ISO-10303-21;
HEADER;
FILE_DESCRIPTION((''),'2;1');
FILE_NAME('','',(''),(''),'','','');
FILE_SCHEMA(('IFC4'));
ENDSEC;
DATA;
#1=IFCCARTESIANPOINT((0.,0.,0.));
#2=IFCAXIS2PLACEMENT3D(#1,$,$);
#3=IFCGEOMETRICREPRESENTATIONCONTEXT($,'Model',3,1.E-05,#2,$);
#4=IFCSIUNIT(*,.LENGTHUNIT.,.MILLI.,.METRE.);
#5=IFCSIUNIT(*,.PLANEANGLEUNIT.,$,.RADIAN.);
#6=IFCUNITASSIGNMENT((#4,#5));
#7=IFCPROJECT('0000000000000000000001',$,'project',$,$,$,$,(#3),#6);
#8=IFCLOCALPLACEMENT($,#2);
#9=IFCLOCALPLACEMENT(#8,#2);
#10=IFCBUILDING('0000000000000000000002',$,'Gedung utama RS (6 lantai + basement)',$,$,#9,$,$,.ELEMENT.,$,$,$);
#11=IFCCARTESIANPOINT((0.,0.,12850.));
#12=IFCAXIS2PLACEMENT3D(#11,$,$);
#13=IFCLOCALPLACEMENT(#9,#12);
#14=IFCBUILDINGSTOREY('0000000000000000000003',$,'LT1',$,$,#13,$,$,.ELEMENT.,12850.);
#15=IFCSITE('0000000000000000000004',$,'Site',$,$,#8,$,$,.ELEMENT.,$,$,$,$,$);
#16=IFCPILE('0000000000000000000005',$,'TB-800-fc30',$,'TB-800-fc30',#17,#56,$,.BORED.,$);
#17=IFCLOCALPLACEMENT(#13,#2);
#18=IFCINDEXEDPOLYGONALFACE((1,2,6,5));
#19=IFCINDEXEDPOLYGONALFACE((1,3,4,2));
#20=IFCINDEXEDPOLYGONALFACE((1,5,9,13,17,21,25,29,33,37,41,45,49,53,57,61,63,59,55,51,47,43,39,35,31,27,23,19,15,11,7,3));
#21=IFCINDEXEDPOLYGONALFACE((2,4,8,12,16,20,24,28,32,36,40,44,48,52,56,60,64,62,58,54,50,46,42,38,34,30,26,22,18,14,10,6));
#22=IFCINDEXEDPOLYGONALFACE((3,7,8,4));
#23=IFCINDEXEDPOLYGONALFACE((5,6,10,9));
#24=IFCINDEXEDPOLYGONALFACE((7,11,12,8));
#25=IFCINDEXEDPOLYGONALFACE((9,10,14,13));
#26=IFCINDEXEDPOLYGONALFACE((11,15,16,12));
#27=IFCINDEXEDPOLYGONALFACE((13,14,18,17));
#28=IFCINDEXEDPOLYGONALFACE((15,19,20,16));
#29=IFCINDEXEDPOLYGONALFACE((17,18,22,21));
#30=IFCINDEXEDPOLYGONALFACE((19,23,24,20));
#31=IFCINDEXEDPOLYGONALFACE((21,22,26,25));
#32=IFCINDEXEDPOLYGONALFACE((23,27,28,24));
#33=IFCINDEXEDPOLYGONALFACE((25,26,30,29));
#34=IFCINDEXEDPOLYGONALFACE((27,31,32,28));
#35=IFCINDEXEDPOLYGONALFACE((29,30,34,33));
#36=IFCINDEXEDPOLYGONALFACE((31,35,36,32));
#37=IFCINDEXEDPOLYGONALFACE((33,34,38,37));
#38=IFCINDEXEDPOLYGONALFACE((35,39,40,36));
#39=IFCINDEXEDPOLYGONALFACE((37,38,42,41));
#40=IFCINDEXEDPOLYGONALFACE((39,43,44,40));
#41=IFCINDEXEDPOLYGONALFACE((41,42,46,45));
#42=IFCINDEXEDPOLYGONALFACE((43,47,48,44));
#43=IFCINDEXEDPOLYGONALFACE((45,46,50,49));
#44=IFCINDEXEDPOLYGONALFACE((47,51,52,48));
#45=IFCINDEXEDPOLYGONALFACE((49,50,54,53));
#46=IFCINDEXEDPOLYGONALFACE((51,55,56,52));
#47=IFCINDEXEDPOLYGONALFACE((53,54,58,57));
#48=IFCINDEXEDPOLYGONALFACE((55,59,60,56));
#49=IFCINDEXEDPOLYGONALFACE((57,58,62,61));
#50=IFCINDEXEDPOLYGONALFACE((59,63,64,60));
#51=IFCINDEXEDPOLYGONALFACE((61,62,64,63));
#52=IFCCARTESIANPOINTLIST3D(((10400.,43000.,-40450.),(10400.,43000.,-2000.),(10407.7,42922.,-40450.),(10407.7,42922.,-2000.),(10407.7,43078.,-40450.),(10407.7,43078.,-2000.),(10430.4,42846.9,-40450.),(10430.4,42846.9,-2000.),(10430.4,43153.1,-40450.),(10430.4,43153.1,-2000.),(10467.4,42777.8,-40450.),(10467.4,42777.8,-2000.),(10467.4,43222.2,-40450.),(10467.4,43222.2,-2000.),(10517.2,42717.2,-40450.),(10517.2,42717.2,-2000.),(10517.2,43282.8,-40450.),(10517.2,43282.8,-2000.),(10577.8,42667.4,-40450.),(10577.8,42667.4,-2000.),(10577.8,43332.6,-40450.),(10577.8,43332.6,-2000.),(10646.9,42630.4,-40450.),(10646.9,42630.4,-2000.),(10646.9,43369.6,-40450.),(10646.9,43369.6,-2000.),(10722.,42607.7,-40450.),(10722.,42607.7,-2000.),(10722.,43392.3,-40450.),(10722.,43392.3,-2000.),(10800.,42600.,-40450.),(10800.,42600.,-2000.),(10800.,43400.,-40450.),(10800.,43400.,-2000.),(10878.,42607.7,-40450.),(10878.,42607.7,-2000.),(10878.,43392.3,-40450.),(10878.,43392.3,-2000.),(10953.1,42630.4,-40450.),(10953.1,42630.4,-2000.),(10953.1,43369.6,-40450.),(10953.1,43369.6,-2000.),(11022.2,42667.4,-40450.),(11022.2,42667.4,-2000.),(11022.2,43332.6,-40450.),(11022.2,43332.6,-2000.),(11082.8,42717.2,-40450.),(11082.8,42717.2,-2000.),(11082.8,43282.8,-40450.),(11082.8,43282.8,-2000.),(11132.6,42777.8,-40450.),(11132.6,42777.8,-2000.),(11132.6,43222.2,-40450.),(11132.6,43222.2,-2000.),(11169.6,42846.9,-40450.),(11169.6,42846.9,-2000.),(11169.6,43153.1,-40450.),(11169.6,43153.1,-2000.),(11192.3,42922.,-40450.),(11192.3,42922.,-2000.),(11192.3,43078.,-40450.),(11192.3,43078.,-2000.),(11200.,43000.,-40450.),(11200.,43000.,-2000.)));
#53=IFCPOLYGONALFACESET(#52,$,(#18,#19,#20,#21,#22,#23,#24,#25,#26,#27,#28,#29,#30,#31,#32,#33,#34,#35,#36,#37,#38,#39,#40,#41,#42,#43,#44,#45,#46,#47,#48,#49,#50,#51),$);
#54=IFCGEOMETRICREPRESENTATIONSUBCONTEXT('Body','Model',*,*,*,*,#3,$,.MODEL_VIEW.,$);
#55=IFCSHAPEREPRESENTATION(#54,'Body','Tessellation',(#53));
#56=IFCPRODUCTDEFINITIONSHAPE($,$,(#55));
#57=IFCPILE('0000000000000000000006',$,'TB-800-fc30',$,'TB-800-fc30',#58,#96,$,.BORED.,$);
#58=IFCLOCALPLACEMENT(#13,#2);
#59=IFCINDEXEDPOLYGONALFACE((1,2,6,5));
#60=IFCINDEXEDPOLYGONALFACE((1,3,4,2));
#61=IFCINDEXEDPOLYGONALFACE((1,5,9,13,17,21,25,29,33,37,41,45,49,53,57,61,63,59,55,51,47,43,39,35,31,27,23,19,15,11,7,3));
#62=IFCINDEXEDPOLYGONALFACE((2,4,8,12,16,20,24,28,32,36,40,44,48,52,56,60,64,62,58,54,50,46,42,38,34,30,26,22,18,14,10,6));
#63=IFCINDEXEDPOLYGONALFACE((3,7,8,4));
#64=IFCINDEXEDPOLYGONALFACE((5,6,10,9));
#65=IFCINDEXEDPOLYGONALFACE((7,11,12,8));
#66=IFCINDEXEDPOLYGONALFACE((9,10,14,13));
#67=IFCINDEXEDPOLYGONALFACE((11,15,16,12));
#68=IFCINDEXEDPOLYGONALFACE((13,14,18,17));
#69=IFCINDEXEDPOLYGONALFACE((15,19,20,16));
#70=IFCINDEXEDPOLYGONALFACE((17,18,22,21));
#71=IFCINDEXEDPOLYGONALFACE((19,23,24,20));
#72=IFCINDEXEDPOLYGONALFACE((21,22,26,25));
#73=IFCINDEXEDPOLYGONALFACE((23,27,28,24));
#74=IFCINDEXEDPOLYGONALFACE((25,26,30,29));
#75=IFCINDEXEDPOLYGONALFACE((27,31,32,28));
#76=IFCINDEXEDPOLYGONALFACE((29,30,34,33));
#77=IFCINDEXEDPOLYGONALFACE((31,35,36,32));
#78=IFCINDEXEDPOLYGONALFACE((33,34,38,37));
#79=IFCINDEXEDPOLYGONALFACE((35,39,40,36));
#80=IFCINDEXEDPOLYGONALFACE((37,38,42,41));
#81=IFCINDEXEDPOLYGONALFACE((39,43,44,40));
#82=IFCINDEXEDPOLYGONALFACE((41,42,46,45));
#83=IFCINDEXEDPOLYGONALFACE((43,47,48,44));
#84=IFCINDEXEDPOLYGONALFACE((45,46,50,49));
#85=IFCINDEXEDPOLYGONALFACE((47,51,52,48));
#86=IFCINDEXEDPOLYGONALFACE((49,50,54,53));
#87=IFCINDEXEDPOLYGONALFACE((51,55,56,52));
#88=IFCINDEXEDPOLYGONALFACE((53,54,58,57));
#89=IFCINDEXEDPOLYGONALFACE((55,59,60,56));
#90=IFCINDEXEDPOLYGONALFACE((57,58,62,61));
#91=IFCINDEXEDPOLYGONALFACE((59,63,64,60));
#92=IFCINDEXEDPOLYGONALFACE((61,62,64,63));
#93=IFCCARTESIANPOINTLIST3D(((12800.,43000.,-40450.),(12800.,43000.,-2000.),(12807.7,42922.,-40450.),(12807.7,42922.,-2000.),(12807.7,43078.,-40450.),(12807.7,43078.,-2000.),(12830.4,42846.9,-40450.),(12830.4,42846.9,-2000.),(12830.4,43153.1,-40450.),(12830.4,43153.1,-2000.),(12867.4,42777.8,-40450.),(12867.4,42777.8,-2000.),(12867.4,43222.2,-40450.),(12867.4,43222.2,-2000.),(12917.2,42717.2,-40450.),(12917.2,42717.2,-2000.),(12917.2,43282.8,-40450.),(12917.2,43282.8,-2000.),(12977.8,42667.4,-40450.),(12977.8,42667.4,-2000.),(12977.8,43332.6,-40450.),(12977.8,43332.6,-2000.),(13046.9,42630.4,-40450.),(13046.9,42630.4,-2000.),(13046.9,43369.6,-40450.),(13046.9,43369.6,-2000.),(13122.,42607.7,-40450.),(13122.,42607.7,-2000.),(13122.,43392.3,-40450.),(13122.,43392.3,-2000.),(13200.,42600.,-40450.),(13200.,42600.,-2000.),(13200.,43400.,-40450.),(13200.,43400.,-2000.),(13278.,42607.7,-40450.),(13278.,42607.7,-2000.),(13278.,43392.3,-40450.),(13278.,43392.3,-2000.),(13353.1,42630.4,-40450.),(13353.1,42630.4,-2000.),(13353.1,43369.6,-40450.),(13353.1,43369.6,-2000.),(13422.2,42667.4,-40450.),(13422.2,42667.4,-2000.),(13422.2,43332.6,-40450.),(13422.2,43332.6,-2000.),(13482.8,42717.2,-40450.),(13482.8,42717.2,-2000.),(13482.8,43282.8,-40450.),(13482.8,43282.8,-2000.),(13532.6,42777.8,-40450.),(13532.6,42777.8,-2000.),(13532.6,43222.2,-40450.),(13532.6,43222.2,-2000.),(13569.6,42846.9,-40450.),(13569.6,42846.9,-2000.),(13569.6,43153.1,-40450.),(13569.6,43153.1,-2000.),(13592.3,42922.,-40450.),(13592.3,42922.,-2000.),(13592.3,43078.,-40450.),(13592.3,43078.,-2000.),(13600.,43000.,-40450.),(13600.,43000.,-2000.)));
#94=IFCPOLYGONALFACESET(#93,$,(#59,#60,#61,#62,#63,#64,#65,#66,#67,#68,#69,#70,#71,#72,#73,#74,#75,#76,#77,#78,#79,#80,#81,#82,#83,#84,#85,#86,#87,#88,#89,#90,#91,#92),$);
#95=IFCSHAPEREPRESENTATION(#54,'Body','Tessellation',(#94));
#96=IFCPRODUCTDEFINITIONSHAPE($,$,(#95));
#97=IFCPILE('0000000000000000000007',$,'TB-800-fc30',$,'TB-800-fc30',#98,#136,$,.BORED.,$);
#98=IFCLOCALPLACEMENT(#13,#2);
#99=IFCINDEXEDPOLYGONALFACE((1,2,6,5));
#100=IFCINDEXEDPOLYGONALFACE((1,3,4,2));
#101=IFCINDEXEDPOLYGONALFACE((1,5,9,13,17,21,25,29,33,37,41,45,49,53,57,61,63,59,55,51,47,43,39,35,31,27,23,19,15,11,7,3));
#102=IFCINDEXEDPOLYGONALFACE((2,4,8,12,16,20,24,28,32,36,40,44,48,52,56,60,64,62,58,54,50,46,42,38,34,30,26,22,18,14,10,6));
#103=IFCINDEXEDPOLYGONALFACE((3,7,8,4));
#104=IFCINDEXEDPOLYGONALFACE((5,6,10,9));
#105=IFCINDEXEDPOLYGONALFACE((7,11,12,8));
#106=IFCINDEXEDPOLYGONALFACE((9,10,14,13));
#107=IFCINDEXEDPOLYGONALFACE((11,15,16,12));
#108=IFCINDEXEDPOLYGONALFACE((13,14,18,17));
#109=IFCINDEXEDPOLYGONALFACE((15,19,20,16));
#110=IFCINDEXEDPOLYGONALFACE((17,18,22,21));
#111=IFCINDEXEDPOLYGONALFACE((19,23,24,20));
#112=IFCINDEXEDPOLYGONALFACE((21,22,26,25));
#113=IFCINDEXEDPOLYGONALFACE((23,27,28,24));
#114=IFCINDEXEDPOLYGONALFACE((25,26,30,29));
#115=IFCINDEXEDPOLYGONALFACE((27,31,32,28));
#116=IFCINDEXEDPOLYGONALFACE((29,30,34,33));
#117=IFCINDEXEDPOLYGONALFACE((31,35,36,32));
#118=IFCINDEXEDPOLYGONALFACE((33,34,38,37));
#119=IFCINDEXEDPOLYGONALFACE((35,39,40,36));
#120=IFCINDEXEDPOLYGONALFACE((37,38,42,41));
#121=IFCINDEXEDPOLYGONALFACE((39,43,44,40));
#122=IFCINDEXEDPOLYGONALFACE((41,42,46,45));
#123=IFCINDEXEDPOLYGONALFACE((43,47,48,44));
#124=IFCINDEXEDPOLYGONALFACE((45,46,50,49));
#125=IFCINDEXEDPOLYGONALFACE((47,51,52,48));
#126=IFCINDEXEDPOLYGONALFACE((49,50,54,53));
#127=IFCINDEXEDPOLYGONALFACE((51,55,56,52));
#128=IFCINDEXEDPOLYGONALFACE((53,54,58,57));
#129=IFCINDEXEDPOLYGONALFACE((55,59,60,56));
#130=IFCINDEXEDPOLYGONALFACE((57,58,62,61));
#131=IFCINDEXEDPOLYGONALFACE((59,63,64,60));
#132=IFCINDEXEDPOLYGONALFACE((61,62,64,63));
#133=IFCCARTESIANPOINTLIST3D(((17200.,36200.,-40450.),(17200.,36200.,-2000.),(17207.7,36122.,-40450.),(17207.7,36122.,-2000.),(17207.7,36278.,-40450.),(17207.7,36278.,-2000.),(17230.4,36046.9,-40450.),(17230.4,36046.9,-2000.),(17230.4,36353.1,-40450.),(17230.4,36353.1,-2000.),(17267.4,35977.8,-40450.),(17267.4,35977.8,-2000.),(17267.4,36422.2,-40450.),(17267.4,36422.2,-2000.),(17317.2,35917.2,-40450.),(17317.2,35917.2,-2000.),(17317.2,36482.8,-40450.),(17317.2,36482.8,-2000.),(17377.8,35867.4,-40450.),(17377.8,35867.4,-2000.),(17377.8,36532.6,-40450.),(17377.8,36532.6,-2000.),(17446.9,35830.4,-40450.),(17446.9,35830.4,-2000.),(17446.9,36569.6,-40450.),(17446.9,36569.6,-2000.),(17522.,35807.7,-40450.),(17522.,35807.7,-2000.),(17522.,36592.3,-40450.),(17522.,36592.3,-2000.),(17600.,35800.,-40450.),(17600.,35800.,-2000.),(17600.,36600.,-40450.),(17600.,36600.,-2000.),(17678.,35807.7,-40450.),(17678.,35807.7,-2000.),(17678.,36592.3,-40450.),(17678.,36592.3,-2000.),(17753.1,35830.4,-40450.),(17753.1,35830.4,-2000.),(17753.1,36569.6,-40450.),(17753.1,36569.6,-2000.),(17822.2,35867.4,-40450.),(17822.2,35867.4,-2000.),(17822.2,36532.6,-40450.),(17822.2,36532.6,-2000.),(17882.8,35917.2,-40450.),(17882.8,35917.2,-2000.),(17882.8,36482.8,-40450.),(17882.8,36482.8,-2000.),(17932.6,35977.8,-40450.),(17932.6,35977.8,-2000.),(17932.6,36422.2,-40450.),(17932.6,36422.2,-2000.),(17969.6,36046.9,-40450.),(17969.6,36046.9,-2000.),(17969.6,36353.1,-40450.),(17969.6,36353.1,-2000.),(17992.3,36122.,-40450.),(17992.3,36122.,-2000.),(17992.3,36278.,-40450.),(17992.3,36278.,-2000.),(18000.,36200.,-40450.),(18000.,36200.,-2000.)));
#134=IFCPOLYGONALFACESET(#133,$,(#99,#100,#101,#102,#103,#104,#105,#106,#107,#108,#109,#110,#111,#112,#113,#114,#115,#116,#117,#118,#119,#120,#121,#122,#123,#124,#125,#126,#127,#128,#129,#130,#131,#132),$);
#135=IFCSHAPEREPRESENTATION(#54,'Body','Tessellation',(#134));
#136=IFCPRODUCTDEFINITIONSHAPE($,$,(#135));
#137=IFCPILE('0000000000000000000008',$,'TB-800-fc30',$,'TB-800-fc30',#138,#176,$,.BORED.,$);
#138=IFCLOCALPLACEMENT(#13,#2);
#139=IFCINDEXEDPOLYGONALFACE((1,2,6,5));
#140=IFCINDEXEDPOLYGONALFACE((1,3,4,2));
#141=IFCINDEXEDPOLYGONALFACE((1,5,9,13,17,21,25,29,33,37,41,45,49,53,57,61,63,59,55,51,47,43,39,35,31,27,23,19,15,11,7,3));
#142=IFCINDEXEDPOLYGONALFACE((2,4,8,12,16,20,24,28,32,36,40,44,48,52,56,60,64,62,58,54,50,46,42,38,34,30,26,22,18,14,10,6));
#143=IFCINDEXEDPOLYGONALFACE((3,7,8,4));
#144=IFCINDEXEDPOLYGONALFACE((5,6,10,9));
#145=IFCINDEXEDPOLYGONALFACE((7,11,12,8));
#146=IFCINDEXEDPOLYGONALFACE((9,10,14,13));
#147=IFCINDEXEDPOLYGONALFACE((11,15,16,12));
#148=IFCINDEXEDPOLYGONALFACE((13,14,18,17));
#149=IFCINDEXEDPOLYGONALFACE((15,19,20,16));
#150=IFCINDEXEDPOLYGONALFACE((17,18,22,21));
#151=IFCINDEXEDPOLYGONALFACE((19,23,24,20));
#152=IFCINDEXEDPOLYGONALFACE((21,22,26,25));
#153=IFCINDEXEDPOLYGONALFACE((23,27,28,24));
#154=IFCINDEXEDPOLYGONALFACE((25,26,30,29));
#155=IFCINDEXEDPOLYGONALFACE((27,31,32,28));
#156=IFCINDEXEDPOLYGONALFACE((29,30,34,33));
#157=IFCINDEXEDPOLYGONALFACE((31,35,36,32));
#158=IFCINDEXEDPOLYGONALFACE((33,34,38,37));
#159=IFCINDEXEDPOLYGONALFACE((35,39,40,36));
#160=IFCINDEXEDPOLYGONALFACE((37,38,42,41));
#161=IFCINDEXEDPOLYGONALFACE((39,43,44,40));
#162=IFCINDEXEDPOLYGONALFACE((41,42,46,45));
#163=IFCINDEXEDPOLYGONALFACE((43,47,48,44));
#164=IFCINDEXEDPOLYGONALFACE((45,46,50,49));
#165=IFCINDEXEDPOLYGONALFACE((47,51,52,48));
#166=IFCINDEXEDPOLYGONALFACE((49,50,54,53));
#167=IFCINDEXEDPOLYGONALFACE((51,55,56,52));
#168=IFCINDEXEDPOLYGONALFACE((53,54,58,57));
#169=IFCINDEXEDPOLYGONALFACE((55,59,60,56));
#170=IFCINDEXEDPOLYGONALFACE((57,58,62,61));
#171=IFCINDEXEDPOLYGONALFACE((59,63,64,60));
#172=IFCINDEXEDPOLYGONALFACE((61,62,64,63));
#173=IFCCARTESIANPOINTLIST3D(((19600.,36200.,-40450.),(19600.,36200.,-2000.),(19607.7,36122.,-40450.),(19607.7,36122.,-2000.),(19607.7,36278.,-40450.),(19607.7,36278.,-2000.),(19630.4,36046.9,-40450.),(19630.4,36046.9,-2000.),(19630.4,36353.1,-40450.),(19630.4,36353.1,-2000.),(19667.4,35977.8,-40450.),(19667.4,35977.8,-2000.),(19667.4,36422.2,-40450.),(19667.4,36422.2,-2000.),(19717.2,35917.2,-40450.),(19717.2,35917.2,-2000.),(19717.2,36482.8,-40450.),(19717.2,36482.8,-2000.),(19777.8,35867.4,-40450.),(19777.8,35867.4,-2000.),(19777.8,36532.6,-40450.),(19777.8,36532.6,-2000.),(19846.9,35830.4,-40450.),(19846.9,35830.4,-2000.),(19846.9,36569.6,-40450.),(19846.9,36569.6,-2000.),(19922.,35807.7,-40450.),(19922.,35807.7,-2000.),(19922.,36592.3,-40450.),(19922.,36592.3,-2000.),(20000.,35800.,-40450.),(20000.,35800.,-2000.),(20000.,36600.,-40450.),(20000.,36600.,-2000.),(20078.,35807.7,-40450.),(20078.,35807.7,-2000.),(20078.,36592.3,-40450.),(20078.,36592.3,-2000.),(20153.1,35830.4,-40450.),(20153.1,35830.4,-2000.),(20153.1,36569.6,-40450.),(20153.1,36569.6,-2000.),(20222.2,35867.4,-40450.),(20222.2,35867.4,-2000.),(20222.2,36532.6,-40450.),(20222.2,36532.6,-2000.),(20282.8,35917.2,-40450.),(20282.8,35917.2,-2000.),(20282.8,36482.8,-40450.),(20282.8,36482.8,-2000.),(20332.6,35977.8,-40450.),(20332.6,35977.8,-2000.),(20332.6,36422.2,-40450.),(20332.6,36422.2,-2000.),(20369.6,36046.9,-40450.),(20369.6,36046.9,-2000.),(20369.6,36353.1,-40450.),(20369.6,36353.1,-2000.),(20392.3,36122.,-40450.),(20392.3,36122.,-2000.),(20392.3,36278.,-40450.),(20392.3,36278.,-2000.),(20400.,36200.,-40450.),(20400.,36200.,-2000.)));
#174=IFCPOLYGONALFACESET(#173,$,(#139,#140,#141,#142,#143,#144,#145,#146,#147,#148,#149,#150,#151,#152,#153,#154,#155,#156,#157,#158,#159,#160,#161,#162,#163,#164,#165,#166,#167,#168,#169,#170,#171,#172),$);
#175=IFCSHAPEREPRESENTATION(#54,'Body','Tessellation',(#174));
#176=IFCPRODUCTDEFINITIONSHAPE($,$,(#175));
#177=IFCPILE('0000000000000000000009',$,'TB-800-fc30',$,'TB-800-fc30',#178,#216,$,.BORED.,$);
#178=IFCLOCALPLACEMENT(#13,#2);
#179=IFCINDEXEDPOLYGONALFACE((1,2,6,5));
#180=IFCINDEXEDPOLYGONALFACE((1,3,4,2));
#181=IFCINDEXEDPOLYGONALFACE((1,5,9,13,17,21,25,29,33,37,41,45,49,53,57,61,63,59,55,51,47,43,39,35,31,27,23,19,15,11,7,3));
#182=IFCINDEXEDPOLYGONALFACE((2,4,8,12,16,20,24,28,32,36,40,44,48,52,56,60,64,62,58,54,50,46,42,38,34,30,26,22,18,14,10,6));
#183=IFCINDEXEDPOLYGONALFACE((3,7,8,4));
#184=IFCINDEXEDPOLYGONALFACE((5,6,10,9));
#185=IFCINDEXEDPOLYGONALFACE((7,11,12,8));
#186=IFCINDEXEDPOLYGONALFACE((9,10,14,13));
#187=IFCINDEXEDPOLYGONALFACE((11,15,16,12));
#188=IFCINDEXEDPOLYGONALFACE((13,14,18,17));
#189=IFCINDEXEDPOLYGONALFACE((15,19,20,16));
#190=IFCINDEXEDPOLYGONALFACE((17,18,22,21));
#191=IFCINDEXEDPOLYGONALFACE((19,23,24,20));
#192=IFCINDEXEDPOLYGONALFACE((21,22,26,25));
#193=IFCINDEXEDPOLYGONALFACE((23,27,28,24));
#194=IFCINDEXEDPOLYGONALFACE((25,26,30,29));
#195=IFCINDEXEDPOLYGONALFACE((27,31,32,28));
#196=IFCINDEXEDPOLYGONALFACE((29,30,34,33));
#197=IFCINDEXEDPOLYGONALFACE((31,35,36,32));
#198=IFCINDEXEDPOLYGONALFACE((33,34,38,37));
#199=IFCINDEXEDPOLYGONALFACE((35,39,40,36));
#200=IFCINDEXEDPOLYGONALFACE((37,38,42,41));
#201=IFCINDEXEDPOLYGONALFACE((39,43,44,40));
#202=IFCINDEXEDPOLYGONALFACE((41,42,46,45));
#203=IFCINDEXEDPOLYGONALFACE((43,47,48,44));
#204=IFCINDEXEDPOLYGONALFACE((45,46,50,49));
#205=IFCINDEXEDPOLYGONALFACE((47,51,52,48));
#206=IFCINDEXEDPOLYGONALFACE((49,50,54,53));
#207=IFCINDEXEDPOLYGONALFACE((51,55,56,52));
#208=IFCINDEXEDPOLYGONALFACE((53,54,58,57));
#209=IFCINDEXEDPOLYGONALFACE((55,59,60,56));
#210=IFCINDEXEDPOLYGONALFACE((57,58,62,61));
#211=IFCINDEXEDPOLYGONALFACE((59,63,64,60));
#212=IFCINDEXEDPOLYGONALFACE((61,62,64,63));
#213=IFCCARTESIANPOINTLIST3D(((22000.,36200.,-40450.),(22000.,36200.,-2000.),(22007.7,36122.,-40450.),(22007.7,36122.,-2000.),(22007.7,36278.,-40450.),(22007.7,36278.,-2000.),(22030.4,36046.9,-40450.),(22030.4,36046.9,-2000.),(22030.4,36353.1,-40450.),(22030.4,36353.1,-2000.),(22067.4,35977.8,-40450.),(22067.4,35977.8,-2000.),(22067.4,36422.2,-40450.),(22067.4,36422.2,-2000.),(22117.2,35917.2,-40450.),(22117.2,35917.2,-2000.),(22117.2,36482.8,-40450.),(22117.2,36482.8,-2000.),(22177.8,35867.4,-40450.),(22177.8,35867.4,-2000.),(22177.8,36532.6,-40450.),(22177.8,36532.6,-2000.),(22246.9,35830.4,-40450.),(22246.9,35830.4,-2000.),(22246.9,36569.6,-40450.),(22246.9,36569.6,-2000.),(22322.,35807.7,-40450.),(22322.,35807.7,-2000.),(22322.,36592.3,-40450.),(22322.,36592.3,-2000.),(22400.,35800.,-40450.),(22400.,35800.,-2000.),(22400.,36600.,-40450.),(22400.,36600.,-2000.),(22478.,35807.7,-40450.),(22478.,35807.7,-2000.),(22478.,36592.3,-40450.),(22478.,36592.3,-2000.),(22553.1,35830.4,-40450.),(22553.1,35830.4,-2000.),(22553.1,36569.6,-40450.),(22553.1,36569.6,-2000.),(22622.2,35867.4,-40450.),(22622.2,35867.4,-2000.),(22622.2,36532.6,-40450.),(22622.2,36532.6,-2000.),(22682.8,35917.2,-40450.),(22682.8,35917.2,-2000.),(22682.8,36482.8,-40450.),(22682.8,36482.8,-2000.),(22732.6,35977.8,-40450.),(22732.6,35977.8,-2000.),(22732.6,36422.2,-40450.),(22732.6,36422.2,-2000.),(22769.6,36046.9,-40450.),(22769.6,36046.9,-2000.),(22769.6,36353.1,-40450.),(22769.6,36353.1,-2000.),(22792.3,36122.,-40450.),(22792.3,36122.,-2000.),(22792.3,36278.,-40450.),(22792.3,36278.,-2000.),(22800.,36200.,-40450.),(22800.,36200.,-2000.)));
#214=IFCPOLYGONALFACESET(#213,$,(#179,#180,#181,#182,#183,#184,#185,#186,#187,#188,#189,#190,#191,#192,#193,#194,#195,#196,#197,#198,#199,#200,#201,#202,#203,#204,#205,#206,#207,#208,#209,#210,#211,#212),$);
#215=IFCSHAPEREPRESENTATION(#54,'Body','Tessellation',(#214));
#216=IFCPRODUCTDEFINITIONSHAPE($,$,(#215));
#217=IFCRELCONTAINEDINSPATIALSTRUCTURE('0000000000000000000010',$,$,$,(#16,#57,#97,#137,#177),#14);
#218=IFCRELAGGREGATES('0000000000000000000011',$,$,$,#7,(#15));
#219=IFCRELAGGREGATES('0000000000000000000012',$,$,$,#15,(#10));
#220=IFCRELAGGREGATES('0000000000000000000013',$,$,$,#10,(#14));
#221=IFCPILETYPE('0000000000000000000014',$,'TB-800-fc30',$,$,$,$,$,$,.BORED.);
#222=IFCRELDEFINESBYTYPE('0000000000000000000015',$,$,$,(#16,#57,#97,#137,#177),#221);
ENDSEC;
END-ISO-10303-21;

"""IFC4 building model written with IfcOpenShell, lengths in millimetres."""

from ifc_helpers import new_model, si_unit, frame, origin, origin_2d, place, context, subcontext, project, spatial, circle, extrude, material_profile, profile_set, profile_usage, type_object, element, save


model = new_model("IFC4")

# Units and contexts
model_context = context("Model", 3, precision=1e-05, world=origin())
body_context = subcontext(model_context, "Body", "Model", "MODEL_VIEW")
ifc_project = project(units=[si_unit("LENGTHUNIT", "METRE", prefix="MILLI"), si_unit("PLANEANGLEUNIT", "RADIAN")], contexts=[model_context])

# Site, building, storey
site_placement = place(None, origin())
site = spatial("IfcSite", under=ifc_project, at=site_placement, Name="Site", CompositionType="ELEMENT")
building_placement = place(site_placement, origin())
building = spatial("IfcBuilding", under=site, at=building_placement, Name="Gedung utama RS (6 lantai + basement)", CompositionType="ELEMENT")
storey_placement = place(building_placement, frame((0.0, 0.0, 12850.0)))
storey = spatial("IfcBuildingStorey", under=building, at=storey_placement, Name="LT1", CompositionType="ELEMENT", Elevation=12850.0)

# Piles
ifc_material_profile_1 = material_profile(None, circle(Radius=400.0, at=origin_2d()), Name="TB-800-fc30")
ifc_profile_set_1 = profile_set([ifc_material_profile_1], Name="TB-800-fc30")
ifc_profile_usage_1 = profile_usage(ifc_profile_set_1, cardinal=5)
pile_type = type_object("IfcPileType", Name="TB-800-fc30", PredefinedType="BORED", material=ifc_profile_set_1)
for number, where, z_axis, x_axis, name in (
    (1, (10800.0, 43000.0, -40450.0), (0.0, 0.0, 1.0), (1.0, 0.0, 0.0), "TB-800-fc30"),
    (2, (13200.0, 43000.0, -40450.0), (0.0, 0.0, 1.0), (1.0, 0.0, 0.0), "TB-800-fc30"),
    (3, (17600.0, 36200.0, -40450.0), (0.0, 0.0, 1.0), (1.0, 0.0, 0.0), "TB-800-fc30"),
    (4, (20000.0, 36200.0, -40450.0), (0.0, 0.0, 1.0), (1.0, 0.0, 0.0), "TB-800-fc30"),
    (5, (22400.0, 36200.0, -40450.0), (0.0, 0.0, 1.0), (1.0, 0.0, 0.0), "TB-800-fc30"),
):
    element("IfcPile", number, at=place(storey_placement, frame(where, z_axis=z_axis, x_axis=x_axis)), inside=storey, type_object=pile_type, material=ifc_profile_usage_1, Name=name, ObjectType="TB-800-fc30", PredefinedType="BORED", context=body_context, shape_type="SweptSolid", body=[
        extrude(circle(Radius=400.0, at=origin_2d()), origin(), (0.0, 0.0, 1.0), 38450.0),
    ])

save(model, "model.ifc")
